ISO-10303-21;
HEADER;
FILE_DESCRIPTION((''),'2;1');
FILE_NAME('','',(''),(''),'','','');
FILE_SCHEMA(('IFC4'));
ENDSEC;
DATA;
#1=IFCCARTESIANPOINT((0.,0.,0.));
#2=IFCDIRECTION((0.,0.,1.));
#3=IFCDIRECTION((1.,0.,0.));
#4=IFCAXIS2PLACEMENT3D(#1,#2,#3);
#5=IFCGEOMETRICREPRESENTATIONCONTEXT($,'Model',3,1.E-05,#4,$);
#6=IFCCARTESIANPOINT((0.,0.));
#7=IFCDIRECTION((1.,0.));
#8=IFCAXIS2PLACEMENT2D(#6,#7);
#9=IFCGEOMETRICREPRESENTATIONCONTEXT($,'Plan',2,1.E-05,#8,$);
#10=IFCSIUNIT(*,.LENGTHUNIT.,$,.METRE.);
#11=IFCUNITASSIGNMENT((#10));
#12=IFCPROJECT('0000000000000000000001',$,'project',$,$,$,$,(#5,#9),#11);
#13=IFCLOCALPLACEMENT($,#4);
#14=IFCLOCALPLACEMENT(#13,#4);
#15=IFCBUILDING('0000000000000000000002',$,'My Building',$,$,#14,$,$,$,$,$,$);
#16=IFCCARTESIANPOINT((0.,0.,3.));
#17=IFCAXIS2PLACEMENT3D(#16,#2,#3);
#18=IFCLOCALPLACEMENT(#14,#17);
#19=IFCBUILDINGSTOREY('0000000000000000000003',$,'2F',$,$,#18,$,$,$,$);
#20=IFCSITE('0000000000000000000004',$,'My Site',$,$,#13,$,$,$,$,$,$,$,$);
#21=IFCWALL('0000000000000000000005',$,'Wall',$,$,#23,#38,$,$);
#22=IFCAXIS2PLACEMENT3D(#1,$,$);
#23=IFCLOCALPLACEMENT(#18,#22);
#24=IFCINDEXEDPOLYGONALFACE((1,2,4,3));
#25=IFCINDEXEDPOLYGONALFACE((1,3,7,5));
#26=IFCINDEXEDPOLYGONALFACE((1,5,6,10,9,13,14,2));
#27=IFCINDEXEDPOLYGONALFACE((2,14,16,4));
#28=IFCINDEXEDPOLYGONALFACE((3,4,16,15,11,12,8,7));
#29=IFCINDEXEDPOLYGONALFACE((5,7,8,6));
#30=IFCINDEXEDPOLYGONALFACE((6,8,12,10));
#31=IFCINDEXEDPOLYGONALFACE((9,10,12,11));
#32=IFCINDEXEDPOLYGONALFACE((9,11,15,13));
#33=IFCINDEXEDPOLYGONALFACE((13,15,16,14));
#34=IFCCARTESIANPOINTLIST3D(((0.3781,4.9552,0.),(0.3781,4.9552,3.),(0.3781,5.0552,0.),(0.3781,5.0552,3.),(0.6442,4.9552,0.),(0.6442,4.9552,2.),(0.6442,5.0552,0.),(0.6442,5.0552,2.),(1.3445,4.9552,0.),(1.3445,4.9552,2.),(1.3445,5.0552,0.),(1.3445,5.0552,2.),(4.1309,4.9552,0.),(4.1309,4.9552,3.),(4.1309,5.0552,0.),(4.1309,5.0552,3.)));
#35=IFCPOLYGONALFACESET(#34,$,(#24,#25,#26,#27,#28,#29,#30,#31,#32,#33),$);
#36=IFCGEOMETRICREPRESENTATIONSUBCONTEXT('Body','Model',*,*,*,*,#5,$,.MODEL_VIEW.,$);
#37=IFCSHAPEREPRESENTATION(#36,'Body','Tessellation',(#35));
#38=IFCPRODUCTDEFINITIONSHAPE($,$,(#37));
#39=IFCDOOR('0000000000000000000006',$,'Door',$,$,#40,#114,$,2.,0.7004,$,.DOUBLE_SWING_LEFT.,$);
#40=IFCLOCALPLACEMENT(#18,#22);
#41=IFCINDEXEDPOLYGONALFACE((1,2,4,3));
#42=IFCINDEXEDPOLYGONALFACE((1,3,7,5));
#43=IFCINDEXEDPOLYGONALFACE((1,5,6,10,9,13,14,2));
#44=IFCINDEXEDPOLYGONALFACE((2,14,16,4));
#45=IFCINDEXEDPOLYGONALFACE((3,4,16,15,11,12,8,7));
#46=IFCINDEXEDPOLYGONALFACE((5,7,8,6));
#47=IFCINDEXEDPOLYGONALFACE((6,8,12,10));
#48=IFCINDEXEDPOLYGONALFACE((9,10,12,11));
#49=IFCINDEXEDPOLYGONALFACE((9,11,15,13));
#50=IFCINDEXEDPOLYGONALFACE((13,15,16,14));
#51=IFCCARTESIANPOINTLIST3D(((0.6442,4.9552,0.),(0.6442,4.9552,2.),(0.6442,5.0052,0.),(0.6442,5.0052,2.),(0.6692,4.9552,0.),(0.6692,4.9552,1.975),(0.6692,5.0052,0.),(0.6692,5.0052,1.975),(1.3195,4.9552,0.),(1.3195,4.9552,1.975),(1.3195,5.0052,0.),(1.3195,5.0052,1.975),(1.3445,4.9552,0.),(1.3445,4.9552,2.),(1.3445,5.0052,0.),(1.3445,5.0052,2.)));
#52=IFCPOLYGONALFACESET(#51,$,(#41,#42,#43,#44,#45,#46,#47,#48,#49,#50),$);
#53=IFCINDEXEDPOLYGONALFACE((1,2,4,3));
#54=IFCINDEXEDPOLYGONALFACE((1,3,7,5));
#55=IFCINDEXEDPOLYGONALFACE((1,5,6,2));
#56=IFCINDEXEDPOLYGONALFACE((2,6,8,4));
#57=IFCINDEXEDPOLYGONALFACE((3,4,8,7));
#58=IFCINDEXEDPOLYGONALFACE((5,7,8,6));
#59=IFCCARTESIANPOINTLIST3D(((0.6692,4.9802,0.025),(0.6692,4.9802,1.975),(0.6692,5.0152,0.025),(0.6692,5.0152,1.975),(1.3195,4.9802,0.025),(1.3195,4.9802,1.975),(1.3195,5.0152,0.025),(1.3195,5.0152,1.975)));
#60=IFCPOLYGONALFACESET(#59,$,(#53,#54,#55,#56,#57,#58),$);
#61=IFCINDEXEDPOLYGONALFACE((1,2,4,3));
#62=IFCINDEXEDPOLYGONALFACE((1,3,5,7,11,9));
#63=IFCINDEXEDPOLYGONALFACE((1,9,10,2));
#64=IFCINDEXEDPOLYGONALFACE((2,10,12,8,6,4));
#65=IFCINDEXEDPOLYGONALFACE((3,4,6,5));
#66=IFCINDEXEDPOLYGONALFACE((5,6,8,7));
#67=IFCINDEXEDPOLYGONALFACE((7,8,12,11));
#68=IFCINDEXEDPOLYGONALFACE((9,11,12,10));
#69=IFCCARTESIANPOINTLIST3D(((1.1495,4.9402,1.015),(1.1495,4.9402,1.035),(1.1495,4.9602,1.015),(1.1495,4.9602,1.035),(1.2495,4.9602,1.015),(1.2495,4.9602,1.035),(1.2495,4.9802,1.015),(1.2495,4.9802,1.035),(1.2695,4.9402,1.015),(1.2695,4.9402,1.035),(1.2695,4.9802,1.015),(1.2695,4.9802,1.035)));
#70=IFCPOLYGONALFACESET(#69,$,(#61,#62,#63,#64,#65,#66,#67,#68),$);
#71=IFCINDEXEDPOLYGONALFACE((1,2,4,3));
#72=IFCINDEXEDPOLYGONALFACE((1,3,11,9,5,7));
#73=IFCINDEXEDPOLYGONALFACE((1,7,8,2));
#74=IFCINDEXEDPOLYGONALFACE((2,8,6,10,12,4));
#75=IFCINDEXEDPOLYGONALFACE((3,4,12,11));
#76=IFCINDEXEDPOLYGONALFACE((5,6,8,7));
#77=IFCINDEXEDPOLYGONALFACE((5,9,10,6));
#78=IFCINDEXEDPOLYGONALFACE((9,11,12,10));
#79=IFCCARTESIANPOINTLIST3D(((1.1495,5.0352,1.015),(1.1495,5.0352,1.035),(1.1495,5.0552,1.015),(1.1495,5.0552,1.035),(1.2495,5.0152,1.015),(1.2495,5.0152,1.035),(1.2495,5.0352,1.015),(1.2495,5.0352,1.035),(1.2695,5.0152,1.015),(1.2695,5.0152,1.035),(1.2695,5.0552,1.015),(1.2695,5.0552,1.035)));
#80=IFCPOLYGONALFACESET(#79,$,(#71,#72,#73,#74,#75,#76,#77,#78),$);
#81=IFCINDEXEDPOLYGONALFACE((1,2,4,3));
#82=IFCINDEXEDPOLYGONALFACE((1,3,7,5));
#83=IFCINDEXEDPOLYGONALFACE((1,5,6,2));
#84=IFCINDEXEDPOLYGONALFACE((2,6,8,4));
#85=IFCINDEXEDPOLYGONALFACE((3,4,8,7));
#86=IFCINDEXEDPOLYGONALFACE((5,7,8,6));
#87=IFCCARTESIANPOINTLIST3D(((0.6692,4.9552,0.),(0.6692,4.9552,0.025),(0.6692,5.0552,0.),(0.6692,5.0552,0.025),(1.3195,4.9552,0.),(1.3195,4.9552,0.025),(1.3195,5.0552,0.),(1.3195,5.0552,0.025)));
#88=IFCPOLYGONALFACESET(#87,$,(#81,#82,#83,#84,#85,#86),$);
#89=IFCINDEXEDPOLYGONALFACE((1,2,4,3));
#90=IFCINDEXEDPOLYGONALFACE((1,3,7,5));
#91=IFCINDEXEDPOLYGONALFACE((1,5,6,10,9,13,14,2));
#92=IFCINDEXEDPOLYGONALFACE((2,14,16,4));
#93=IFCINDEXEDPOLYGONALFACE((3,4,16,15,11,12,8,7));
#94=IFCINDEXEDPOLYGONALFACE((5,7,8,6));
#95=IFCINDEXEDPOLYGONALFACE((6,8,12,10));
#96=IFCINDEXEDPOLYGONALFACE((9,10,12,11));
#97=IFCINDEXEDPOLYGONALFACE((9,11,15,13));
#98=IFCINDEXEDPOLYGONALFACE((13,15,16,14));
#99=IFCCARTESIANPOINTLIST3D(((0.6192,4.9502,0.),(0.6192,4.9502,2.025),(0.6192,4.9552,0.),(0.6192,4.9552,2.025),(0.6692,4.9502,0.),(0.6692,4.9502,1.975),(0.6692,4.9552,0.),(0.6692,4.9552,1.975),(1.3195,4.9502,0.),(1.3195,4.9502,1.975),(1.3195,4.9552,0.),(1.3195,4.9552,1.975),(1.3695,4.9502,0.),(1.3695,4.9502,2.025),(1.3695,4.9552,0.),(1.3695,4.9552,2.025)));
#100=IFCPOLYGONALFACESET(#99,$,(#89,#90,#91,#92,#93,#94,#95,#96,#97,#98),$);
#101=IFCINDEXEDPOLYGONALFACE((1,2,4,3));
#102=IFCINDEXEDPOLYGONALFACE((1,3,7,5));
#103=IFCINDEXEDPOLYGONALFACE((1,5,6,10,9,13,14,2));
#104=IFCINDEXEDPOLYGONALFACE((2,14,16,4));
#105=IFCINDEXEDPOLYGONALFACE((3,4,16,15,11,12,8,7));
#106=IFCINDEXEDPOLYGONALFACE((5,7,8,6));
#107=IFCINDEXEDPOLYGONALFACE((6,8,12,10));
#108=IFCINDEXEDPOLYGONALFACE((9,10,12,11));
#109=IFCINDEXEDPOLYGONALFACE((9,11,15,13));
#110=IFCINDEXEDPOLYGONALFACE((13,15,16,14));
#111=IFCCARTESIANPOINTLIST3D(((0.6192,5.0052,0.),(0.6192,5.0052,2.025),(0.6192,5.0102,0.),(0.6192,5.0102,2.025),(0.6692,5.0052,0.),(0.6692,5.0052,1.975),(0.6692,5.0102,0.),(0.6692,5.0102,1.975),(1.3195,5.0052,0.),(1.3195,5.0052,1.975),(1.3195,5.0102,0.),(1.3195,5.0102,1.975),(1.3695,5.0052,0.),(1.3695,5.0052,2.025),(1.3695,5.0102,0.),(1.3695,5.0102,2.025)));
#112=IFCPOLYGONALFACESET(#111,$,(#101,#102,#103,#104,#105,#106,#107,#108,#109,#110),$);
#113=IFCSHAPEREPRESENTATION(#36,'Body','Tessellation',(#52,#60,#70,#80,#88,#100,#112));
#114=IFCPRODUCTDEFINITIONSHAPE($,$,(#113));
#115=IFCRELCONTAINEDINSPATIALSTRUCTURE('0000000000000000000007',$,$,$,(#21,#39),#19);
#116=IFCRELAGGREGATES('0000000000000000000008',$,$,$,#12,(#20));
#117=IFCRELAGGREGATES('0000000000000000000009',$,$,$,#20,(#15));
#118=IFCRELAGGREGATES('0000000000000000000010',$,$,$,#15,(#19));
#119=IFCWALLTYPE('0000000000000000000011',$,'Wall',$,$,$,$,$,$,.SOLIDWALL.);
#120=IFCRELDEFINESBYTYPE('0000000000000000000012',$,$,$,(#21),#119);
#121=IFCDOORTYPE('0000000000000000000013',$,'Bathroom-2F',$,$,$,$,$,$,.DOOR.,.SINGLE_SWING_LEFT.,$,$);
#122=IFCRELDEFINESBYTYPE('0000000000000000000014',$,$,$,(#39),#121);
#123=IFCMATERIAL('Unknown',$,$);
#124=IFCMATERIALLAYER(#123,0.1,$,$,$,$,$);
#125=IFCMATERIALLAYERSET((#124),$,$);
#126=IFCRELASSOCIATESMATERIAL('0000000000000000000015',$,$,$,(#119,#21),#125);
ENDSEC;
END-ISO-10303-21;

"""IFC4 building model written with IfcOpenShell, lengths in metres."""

from ifc_helpers import new_model, entity, si_unit, frame, origin_with_axes, origin_2d_with_axis, place, context, subcontext, project, spatial, line, indexed_curve, outline, extrude, shape, source, transform, mapped, material, layer, layer_set, layer_usage, type_object, type_shapes, element, fill, save


model = new_model("IFC4")

# Units and contexts
model_context = context("Model", 3, precision=1e-05, world=origin_with_axes())
plan_context = context("Plan", 2, precision=1e-05, world=origin_2d_with_axis())
body_context_1 = subcontext(model_context, "Body", "Model", "MODEL_VIEW")
body_context_2 = subcontext(plan_context, "Body", "Plan", "PLAN_VIEW")
ifc_project = project(units=[si_unit("LENGTHUNIT", "METRE")], contexts=[model_context, plan_context])

# Site, building, storey
site_placement = place(None, origin_with_axes())
site = spatial("IfcSite", under=ifc_project, at=site_placement, Name="My Site")
building_placement = place(site_placement, origin_with_axes())
building = spatial("IfcBuilding", under=site, at=building_placement, Name="My Building")
storey_placement = place(building_placement, frame((0.0, 0.0, 3.0), z_axis=(0.0, 0.0, 1.0), x_axis=(1.0, 0.0, 0.0)))
storey = spatial("IfcBuildingStorey", under=building, at=storey_placement, Name="2F")

# Shared definitions
ifc_material = material(Name="Unknown")

# Shared definitions
ifc_layer_1 = layer(ifc_material, 0.1)
ifc_layer_set_1 = layer_set([ifc_layer_1])
wall_type = type_object("IfcWallType", Name="Wall", PredefinedType="SOLIDWALL", material=ifc_layer_set_1)

# Wall, opening, door
ifc_layer_usage_1 = layer_usage(ifc_layer_set_1, "AXIS2", "POSITIVE", 0.0)
wall_1_placement = place(storey_placement, frame((4.2309, 5.0552, 0.0), z_axis=(0.0, 0.0, 1.0), x_axis=(-1.0, 0.0, 0.0)))
wall_1 = element("IfcWall", 1, at=wall_1_placement, inside=storey, type_object=wall_type, material=ifc_layer_usage_1, Name="Wall", context=body_context_1, shape_type="SweptSolid", body=[
    extrude(outline(indexed_curve([(0.1, 0.0), (0.1, 0.1), (3.8528, 0.1), (3.8528, 0.0)], segments=[line(1, 2, 3, 4, 1)])), origin_with_axes(), (0.0, 0.0, 1.0), 3.0),
])
shared_shape_1 = source(origin_with_axes(), body_context_1, "Body", "SweptSolid", [
    extrude(outline(indexed_curve([(0.0, 0.0), (0.7004, 0.0), (0.7004, 2.0), (0.0, 2.0)], segments=[line(1, 2, 3, 4, 1)])), frame((0.0, -0.6, 0.0), z_axis=(0.0, -1.0, 0.0), x_axis=(1.0, 0.0, 0.0)), (0.0, 0.0, -1.0), 1.2),
])
opening_1_placement = place(wall_1_placement, frame((3.5867, 0.1, 0.0), z_axis=(0.0, 0.0, 1.0), x_axis=(-1.0, 0.0, 0.0)))
opening_1 = element("IfcOpeningElement", 2, at=opening_1_placement, cuts=wall_1, PredefinedType="OPENING", context=body_context_1, shape_type="MappedRepresentation", body=[
    mapped(shared_shape_1, transform((0.0, 0.0, 0.0), x_axis=(1.0, 0.0, 0.0), y_axis=(0.0, 1.0, 0.0), z_axis=(0.0, 0.0, 1.0), scale=1.0)),
])
door_type_1 = type_object("IfcDoorType", Name="Bathroom-2F", OperationType="SINGLE_SWING_LEFT", PredefinedType="DOOR")
shared_shape_2 = source(origin_with_axes(), body_context_1, "Body", "SweptSolid", [
    extrude(outline(indexed_curve([(0.0, 0.0), (0.0, 2.0), (0.7004, 2.0), (0.7004, 0.0), (0.6754, 0.0), (0.6754, 1.975), (0.025, 1.975), (0.025, 0.0)], segments=[line(1, 2, 3, 4, 5, 6, 7, 8, 1)])), frame((0.0, 0.0, 0.0), z_axis=(0.0, -1.0, 0.0), x_axis=(1.0, 0.0, 0.0)), (0.0, 0.0, -1.0), 0.05),
    extrude(outline(indexed_curve([(0.0, 0.0), (0.6504, 0.0), (0.6504, 0.035), (0.0, 0.035)], segments=[line(1, 2, 3, 4, 1)])), frame((0.025, 0.025, 0.025), z_axis=(0.0, 0.0, 1.0), x_axis=(1.0, 0.0, 0.0)), (0.0, 0.0, 1.0), 1.95),
    extrude(outline(indexed_curve([(0.0, 0.0), (0.0, -0.04), (-0.12, -0.04), (-0.12, -0.02), (-0.02, -0.02), (-0.02, 0.0)], segments=[line(1, 2, 3, 4, 5, 6, 1)])), frame((0.6254, 0.025, 1.015), z_axis=(0.0, 0.0, 1.0), x_axis=(1.0, 0.0, 0.0)), (0.0, 0.0, 1.0), 0.02),
    extrude(outline(indexed_curve([(0.0, 0.0), (0.0, 0.04), (-0.12, 0.04), (-0.12, 0.02), (-0.02, 0.02), (-0.02, 0.0)], segments=[line(1, 2, 3, 4, 5, 6, 1)])), frame((0.6254, 0.06, 1.015), z_axis=(0.0, 0.0, 1.0), x_axis=(1.0, 0.0, 0.0)), (0.0, 0.0, 1.0), 0.02),
    extrude(outline(indexed_curve([(0.0, 0.0), (0.6504, 0.0), (0.6504, 0.1), (0.0, 0.1)], segments=[line(1, 2, 3, 4, 1)])), frame((0.025, 0.0, 0.0), z_axis=(0.0, 0.0, 1.0), x_axis=(1.0, 0.0, 0.0)), (0.0, 0.0, 1.0), 0.025),
    extrude(outline(indexed_curve([(0.0, 0.0), (0.0, 2.025), (0.7504, 2.025), (0.7504, 0.0), (0.7004, 0.0), (0.7004, 1.975), (0.05, 1.975), (0.05, 0.0)], segments=[line(1, 2, 3, 4, 5, 6, 7, 8, 1)])), frame((-0.025, -0.005, 0.0), z_axis=(0.0, -1.0, 0.0), x_axis=(1.0, 0.0, 0.0)), (0.0, 0.0, -1.0), 0.005),
    extrude(outline(indexed_curve([(0.0, 0.0), (0.0, 2.025), (0.7504, 2.025), (0.7504, 0.0), (0.7004, 0.0), (0.7004, 1.975), (0.05, 1.975), (0.05, 0.0)], segments=[line(1, 2, 3, 4, 5, 6, 7, 8, 1)])), frame((-0.025, 0.05, 0.0), z_axis=(0.0, -1.0, 0.0), x_axis=(1.0, 0.0, 0.0)), (0.0, 0.0, -1.0), 0.005),
])
shared_shape_3 = source(origin_with_axes(), body_context_2, "Body", "Curve2D", [
    entity("IfcIndexedPolyCurve", entity("IfcCartesianPointList2D", [[0.0, 0.0], [0.025, 0.0], [0.025, 0.05], [0.0, 0.05]]), [entity("IfcLineIndex", [1, 2, 3, 4, 1])]),
    entity("IfcIndexedPolyCurve", entity("IfcCartesianPointList2D", [[0.7004, 0.0], [0.6754, 0.0], [0.6754, 0.05], [0.7004, 0.05]]), [entity("IfcLineIndex", [1, 2, 3, 4, 1])]),
    entity("IfcIndexedPolyCurve", entity("IfcCartesianPointList2D", [[0.025, 0.05], [0.025, -0.6004], [0.06, -0.6004]])),
    entity("IfcTrimmedCurve", entity("IfcEllipse", entity("IfcAxis2Placement2D", entity("IfcCartesianPoint", [0.06, 0.05]), entity("IfcDirection", [1.0, 0.0])), 0.6154, 0.6504), [entity("IfcCartesianPoint", [0.06, -0.6004])], [entity("IfcCartesianPoint", [0.06, 0.7004])], True, "CARTESIAN"),
    entity("IfcIndexedPolyCurve", entity("IfcCartesianPointList2D", [[0.025, 0.05], [0.06, 0.05], [0.06, 0.7004], [0.025, 0.7004]]), [entity("IfcLineIndex", [1, 2, 3, 4, 1])]),
])
type_shapes(door_type_1, [shared_shape_2, shared_shape_3])
door_1_placement = place(opening_1_placement, origin_with_axes())
door_1 = element("IfcDoor", 3, at=door_1_placement, inside=storey, type_object=door_type_1, Name="Door", OperationType="DOUBLE_SWING_LEFT", OverallHeight=2.0, OverallWidth=0.7004, shapes=[
    shape(body_context_1, "Body", "MappedRepresentation", [mapped(shared_shape_2, transform((0.0, 0.0, 0.0), x_axis=(1.0, 0.0, 0.0), y_axis=(0.0, 1.0, 0.0), z_axis=(0.0, 0.0, 1.0), scale=1.0))]),
    shape(body_context_2, "Body", "MappedRepresentation", [mapped(shared_shape_3, transform((0.0, 0.0, 0.0), x_axis=(1.0, 0.0, 0.0), y_axis=(0.0, 1.0, 0.0), z_axis=(0.0, 0.0, 1.0), scale=1.0))]),
])
fill(opening_1, door_1)

save(model, "model.ifc")
